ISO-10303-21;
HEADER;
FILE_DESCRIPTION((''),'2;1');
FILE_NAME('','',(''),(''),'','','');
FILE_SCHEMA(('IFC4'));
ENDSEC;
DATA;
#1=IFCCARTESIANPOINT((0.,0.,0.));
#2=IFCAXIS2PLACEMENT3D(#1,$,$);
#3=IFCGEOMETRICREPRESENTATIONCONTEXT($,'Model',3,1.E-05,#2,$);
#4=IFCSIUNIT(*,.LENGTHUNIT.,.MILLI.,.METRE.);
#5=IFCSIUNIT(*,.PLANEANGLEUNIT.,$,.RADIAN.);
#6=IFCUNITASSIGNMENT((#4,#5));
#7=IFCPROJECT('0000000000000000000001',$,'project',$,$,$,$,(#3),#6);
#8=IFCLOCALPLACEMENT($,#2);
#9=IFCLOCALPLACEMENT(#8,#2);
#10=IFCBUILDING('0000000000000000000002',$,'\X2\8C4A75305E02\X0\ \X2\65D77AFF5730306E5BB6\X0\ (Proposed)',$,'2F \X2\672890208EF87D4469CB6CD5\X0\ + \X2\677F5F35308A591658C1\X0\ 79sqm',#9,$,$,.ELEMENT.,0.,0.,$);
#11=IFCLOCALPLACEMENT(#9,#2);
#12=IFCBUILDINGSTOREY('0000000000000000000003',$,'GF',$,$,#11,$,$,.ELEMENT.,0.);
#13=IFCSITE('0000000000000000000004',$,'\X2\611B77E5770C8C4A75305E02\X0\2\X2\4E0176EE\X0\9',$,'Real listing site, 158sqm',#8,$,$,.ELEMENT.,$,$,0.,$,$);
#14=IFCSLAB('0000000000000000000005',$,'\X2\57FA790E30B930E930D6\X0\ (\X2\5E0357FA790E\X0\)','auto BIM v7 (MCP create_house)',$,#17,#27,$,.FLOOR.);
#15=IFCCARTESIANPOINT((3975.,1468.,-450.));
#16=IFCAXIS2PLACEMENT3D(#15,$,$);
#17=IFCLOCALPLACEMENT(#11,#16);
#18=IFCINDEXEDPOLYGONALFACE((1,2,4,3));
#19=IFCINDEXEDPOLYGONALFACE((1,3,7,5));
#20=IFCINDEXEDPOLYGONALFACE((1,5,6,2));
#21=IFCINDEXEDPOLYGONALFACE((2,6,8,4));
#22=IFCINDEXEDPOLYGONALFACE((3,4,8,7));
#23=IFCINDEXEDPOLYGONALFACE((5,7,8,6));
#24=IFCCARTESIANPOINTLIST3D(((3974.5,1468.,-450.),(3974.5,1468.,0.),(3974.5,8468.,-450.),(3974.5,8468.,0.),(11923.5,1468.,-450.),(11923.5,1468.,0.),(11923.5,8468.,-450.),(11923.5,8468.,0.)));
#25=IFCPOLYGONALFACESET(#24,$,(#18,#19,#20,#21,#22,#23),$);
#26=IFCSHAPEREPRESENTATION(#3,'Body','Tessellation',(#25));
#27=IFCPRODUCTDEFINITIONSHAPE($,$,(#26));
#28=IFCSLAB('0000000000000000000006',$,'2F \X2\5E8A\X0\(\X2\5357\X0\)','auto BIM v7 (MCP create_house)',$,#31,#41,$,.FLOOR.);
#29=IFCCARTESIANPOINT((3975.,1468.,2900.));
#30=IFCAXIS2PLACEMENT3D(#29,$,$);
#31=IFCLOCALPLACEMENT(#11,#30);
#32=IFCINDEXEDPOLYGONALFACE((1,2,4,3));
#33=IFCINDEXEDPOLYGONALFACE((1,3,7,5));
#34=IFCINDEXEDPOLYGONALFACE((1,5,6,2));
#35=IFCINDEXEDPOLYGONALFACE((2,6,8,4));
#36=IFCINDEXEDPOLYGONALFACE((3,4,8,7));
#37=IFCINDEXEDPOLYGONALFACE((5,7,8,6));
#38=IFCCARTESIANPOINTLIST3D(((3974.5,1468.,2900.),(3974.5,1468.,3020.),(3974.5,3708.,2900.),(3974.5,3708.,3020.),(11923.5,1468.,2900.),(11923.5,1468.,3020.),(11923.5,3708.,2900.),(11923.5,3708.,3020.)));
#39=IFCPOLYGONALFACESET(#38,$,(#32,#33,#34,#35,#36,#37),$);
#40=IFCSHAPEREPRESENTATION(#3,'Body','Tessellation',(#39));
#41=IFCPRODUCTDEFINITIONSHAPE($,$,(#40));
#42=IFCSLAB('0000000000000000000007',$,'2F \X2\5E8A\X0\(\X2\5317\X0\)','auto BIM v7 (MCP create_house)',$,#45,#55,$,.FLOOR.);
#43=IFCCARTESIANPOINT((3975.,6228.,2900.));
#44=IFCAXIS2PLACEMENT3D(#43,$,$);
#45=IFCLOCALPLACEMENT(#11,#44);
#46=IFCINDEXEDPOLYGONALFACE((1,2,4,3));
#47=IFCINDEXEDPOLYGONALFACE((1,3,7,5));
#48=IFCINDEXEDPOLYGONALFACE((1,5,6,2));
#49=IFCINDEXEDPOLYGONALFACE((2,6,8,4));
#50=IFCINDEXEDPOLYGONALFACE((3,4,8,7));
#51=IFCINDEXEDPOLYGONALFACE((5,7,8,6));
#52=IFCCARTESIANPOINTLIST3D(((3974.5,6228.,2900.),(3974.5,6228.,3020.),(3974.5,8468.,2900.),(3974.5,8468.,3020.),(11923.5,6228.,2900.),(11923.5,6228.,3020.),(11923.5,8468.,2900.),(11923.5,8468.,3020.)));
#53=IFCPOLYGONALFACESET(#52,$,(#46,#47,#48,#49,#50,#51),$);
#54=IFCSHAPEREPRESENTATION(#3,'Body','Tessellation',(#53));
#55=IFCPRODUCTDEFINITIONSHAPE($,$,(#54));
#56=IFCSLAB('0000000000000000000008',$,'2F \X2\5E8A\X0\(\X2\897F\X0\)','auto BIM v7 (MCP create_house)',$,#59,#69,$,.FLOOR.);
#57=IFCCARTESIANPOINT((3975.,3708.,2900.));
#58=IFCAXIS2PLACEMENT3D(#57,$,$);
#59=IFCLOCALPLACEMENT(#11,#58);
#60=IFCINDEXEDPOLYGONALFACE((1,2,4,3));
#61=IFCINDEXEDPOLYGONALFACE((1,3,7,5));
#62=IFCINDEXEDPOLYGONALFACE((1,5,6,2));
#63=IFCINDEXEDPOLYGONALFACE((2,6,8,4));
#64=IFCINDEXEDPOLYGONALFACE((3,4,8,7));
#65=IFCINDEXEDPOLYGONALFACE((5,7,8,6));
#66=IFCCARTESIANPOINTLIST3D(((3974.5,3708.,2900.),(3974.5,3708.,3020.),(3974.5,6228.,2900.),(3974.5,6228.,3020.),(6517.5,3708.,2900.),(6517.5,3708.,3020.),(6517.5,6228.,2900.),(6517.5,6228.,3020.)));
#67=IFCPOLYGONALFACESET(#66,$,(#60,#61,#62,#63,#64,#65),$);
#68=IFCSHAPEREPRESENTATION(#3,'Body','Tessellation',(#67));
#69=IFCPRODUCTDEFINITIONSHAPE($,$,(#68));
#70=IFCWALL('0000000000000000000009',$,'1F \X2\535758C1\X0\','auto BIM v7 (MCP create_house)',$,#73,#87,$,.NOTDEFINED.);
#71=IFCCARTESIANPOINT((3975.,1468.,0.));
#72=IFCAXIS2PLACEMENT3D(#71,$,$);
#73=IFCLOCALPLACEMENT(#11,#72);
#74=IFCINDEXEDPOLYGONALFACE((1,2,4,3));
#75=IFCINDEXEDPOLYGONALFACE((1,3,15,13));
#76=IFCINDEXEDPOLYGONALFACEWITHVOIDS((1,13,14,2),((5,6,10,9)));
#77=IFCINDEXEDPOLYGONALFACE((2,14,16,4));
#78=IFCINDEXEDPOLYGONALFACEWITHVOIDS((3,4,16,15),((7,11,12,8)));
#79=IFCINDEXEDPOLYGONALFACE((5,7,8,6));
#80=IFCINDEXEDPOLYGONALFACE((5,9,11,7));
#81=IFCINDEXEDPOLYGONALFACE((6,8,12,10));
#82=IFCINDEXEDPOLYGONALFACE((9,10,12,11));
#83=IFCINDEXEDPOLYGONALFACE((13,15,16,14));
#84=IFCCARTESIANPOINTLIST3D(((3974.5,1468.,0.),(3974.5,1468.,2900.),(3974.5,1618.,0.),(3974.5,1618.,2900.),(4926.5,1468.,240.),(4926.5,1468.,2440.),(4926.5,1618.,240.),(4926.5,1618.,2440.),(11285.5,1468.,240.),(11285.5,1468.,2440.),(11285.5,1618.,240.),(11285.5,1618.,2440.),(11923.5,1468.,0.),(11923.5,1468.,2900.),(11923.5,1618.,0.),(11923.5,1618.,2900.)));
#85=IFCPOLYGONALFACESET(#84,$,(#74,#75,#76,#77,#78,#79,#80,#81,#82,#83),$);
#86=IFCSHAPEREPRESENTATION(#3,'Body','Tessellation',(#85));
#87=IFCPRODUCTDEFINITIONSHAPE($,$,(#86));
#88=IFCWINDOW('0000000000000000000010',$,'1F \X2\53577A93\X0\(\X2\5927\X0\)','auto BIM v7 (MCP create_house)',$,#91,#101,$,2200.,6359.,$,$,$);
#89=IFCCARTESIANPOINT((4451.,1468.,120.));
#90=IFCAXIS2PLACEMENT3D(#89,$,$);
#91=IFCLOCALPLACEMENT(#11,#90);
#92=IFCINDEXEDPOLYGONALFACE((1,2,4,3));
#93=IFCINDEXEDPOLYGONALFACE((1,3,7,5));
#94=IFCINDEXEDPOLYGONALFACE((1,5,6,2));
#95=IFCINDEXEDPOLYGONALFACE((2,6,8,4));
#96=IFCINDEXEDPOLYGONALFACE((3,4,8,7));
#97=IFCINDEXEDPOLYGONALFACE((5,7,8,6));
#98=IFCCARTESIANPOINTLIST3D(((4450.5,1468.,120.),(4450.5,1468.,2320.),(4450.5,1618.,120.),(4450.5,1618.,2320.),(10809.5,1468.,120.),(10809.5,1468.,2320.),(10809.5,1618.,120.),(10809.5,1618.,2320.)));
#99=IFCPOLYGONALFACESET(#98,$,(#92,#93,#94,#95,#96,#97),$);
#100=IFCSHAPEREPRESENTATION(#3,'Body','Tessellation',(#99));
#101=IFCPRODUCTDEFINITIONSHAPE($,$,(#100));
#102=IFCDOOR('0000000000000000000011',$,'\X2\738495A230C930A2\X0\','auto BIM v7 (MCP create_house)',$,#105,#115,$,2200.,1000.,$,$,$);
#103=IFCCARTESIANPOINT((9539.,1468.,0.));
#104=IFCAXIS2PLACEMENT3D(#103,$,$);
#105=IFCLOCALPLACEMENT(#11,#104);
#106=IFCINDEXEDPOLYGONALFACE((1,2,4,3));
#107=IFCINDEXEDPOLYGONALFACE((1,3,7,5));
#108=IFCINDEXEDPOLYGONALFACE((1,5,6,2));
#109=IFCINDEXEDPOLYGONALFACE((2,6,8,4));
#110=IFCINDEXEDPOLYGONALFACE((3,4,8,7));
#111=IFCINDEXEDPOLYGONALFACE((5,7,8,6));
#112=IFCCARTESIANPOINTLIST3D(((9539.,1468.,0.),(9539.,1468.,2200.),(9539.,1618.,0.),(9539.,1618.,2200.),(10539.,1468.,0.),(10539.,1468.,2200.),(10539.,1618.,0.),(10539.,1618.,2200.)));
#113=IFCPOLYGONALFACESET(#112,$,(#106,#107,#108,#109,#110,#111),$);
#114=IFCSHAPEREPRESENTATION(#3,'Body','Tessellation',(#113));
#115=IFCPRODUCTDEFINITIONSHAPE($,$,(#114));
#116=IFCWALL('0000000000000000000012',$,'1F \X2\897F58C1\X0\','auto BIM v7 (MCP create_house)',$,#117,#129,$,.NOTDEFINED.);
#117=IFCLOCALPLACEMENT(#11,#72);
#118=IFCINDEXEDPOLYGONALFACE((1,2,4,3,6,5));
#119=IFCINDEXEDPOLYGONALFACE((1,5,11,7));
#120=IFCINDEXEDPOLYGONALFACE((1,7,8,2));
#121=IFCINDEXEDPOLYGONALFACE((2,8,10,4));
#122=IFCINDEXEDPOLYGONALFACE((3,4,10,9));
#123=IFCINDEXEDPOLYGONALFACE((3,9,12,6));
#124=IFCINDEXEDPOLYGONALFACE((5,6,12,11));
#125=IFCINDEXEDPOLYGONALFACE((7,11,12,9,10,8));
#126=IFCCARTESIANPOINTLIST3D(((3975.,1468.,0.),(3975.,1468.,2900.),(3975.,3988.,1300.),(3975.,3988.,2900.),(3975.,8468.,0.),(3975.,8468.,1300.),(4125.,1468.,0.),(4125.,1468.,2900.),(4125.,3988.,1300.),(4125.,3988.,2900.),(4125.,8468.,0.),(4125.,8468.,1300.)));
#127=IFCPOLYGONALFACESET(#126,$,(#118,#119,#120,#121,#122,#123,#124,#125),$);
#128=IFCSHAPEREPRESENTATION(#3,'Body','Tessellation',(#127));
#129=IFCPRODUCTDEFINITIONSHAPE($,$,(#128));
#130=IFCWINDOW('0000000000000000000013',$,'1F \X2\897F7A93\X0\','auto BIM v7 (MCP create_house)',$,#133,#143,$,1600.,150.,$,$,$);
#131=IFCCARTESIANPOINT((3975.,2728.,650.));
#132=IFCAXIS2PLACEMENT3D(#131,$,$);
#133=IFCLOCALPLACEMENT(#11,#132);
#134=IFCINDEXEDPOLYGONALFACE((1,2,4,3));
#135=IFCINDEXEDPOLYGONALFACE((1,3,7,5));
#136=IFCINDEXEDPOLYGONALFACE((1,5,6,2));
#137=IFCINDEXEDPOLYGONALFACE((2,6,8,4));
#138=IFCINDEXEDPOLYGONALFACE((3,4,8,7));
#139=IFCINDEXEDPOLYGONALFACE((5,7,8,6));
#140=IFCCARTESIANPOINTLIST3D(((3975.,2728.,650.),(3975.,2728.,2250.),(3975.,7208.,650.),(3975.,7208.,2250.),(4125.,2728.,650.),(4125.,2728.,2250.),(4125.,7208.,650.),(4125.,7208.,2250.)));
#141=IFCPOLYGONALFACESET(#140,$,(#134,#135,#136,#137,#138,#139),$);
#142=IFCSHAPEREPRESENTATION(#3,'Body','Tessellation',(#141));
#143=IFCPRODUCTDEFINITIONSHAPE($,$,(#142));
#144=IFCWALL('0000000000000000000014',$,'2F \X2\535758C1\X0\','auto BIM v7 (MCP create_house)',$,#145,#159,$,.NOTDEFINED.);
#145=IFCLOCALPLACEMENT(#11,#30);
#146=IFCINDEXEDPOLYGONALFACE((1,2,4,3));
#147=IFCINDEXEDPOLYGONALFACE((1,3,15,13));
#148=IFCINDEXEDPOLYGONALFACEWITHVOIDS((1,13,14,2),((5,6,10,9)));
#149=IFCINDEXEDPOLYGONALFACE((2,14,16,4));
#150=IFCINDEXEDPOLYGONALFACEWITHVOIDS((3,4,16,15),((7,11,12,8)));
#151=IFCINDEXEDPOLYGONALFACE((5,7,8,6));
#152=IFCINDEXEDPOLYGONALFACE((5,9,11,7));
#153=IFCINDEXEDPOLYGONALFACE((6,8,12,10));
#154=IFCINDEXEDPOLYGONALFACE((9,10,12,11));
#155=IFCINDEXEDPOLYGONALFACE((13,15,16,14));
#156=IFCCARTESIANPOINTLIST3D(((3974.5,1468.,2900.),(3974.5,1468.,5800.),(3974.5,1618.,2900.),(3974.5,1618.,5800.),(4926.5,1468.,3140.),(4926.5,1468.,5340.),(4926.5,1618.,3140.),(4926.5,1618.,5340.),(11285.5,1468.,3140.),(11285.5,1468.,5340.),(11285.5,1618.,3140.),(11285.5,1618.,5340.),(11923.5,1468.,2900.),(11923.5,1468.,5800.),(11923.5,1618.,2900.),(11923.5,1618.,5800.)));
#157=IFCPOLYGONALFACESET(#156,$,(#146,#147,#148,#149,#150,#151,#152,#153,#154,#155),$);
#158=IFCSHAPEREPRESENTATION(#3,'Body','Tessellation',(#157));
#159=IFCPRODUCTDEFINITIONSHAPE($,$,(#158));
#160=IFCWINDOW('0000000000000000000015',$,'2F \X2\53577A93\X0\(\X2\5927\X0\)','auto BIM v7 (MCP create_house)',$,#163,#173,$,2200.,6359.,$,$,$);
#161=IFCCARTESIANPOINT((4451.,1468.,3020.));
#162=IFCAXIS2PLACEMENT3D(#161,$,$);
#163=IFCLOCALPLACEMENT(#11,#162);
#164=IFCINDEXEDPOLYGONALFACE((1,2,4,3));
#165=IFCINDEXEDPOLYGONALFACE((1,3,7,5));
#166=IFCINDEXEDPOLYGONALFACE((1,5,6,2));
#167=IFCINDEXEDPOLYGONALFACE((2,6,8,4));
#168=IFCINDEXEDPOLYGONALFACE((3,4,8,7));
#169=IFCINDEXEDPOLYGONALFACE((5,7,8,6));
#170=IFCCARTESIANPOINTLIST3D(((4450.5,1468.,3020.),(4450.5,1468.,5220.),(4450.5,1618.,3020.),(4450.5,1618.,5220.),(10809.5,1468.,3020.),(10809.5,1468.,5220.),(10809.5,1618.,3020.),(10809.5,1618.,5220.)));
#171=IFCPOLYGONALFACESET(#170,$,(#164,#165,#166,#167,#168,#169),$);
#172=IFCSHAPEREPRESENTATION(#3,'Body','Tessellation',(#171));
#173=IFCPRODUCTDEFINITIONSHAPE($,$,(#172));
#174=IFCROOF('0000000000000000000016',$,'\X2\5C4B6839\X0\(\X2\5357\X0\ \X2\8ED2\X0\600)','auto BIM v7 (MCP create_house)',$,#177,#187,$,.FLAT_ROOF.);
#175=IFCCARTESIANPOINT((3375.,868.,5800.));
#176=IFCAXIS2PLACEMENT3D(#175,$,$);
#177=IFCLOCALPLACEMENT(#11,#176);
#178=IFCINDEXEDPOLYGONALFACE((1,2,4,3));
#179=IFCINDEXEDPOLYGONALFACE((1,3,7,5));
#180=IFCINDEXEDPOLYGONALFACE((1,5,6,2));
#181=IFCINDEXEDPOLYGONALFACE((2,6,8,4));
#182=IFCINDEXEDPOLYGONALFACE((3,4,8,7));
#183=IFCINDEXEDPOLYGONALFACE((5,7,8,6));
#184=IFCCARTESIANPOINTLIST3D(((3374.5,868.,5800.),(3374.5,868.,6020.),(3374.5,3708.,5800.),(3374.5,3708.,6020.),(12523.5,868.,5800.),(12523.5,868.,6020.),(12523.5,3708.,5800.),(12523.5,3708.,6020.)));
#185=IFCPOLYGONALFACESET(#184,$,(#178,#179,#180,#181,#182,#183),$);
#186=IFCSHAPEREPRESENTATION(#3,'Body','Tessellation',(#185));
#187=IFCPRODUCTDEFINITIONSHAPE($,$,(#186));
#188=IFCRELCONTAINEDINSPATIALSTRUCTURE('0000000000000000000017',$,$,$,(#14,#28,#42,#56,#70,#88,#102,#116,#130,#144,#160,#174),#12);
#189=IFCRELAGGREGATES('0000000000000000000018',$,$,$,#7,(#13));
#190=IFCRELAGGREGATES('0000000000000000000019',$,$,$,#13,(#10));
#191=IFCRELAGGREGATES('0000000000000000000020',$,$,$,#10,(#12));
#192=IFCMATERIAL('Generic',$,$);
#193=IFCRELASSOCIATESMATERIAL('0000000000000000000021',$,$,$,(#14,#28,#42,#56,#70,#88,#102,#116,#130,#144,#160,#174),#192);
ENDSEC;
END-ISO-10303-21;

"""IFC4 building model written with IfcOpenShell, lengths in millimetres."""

from ifc_helpers import new_model, si_unit, frame, frame_2d, origin, place, context, project, spatial, rectangle, extrude, material, element, fill, save


model = new_model("IFC4")

# Units and contexts
model_context = context("Model", 3, precision=1e-05, world=origin())
ifc_project = project(units=[si_unit("LENGTHUNIT", "METRE", prefix="MILLI"), si_unit("PLANEANGLEUNIT", "RADIAN")], contexts=[model_context])

# Site, building, storey
site_placement = place(None, origin())
site = spatial("IfcSite", under=ifc_project, at=site_placement, Name="愛知県豊田市2丁目9", ObjectType="Real listing site, 158sqm", CompositionType="ELEMENT", RefElevation=0.0)
building_placement = place(site_placement, origin())
building = spatial("IfcBuilding", under=site, at=building_placement, Name="豊田市 旗竿地の家 (Proposed)", ObjectType="2F 木造軸組構法 + 板張り外壁 79sqm", CompositionType="ELEMENT", ElevationOfRefHeight=0.0, ElevationOfTerrain=0.0)
storey_placement = place(building_placement, origin())
storey = spatial("IfcBuildingStorey", under=building, at=storey_placement, Name="GF", CompositionType="ELEMENT", Elevation=0.0)

# Slabs
ifc_material = material(Name="Generic")
slab_1_placement = place(storey_placement, frame((3975.0, 1468.0, -450.0)))
element("IfcSlab", 1, at=slab_1_placement, inside=storey, material=ifc_material, Name="基礎スラブ (布基礎)", Description="auto BIM v7 (MCP create_house)", PredefinedType="FLOOR", context=model_context, shape_type="SweptSolid", body=[
    extrude(rectangle(XDim=7949.0, YDim=7000.0, at=frame_2d((3974.0, 3500.0))), frame((3975.0, 1468.0, -450.0)), (0.0, 0.0, 1.0), 450.0),
])
slab_2_placement = place(storey_placement, frame((3975.0, 1468.0, 2900.0)))
element("IfcSlab", 2, at=slab_2_placement, inside=storey, material=ifc_material, Name="2F 床(南)", Description="auto BIM v7 (MCP create_house)", PredefinedType="FLOOR", context=model_context, shape_type="SweptSolid", body=[
    extrude(rectangle(XDim=7949.0, YDim=2240.0, at=frame_2d((3974.0, 1120.0))), frame((3975.0, 1468.0, 2900.0)), (0.0, 0.0, 1.0), 120.0),
])
slab_3_placement = place(storey_placement, frame((3975.0, 6228.0, 2900.0)))
element("IfcSlab", 3, at=slab_3_placement, inside=storey, material=ifc_material, Name="2F 床(北)", Description="auto BIM v7 (MCP create_house)", PredefinedType="FLOOR", context=model_context, shape_type="SweptSolid", body=[
    extrude(rectangle(XDim=7949.0, YDim=2240.0, at=frame_2d((3974.0, 1120.0))), frame((3975.0, 6228.0, 2900.0)), (0.0, 0.0, 1.0), 120.0),
])
slab_4_placement = place(storey_placement, frame((3975.0, 3708.0, 2900.0)))
element("IfcSlab", 4, at=slab_4_placement, inside=storey, material=ifc_material, Name="2F 床(西)", Description="auto BIM v7 (MCP create_house)", PredefinedType="FLOOR", context=model_context, shape_type="SweptSolid", body=[
    extrude(rectangle(XDim=2543.0, YDim=2520.0, at=frame_2d((1271.0, 1260.0))), frame((3975.0, 3708.0, 2900.0)), (0.0, 0.0, 1.0), 120.0),
])

# Wall, openings, window, door
wall_1_placement = place(storey_placement, frame((3975.0, 1468.0, 0.0)))
wall_1 = element("IfcWall", 5, at=wall_1_placement, inside=storey, material=ifc_material, Name="1F 南壁", Description="auto BIM v7 (MCP create_house)", PredefinedType="NOTDEFINED", context=model_context, shape_type="SweptSolid", body=[
    extrude(rectangle(XDim=7949.0, YDim=150.0, at=frame_2d((3974.0, 75.0))), frame((3975.0, 1468.0, 0.0)), (0.0, 0.0, 1.0), 2900.0),
])
opening_1_placement = place(storey_placement, frame((4451.0, 1468.0, 120.0)))
opening_1 = element("IfcOpeningElement", 6, at=opening_1_placement, cuts=wall_1, PredefinedType="NOTDEFINED", context=model_context, shape_type="SweptSolid", body=[
    extrude(rectangle(XDim=6359.0, YDim=150.0, at=frame_2d((3179.0, 75.0))), frame((4451.0, 1468.0, 120.0)), (0.0, 0.0, 1.0), 2200.0),
])
opening_2_placement = place(storey_placement, frame((9539.0, 1468.0, 0.0)))
opening_2 = element("IfcOpeningElement", 7, at=opening_2_placement, cuts=wall_1, PredefinedType="NOTDEFINED", context=model_context, shape_type="SweptSolid", body=[
    extrude(rectangle(XDim=1000.0, YDim=150.0, at=frame_2d((500.0, 75.0))), frame((9539.0, 1468.0, 0.0)), (0.0, 0.0, 1.0), 2200.0),
])
window_1_placement = place(storey_placement, frame((4451.0, 1468.0, 120.0)))
window_1 = element("IfcWindow", 8, at=window_1_placement, inside=storey, material=ifc_material, Name="1F 南窓(大)", Description="auto BIM v7 (MCP create_house)", OverallHeight=2200.0, OverallWidth=6359.0, context=model_context, shape_type="SweptSolid", body=[
    extrude(rectangle(XDim=6359.0, YDim=150.0, at=frame_2d((3179.0, 75.0))), frame((4451.0, 1468.0, 120.0)), (0.0, 0.0, 1.0), 2200.0),
])
fill(opening_1, window_1)
door_placement = place(storey_placement, frame((9539.0, 1468.0, 0.0)))
door = element("IfcDoor", 9, at=door_placement, inside=storey, material=ifc_material, Name="玄関ドア", Description="auto BIM v7 (MCP create_house)", OverallHeight=2200.0, OverallWidth=1000.0, context=model_context, shape_type="SweptSolid", body=[
    extrude(rectangle(XDim=1000.0, YDim=150.0, at=frame_2d((500.0, 75.0))), frame((9539.0, 1468.0, 0.0)), (0.0, 0.0, 1.0), 2200.0),
])
fill(opening_2, door)

# Walls, openings, windows
wall_2_placement = place(storey_placement, frame((3975.0, 1468.0, 0.0)))
wall_2 = element("IfcWall", 10, at=wall_2_placement, inside=storey, material=ifc_material, Name="1F 西壁", Description="auto BIM v7 (MCP create_house)", PredefinedType="NOTDEFINED", context=model_context, shape_type="SweptSolid", body=[
    extrude(rectangle(XDim=150.0, YDim=7000.0, at=frame_2d((75.0, 3500.0))), frame((3975.0, 1468.0, 0.0)), (0.0, 0.0, 1.0), 2900.0),
])
opening_3_placement = place(storey_placement, frame((3975.0, 2728.0, 650.0)))
opening_3 = element("IfcOpeningElement", 11, at=opening_3_placement, cuts=wall_2, PredefinedType="NOTDEFINED", context=model_context, shape_type="SweptSolid", body=[
    extrude(rectangle(XDim=150.0, YDim=4480.0, at=frame_2d((75.0, 2240.0))), frame((3975.0, 2728.0, 650.0)), (0.0, 0.0, 1.0), 1600.0),
])
window_2_placement = place(storey_placement, frame((3975.0, 2728.0, 650.0)))
window_2 = element("IfcWindow", 12, at=window_2_placement, inside=storey, material=ifc_material, Name="1F 西窓", Description="auto BIM v7 (MCP create_house)", OverallHeight=1600.0, OverallWidth=150.0, context=model_context, shape_type="SweptSolid", body=[
    extrude(rectangle(XDim=150.0, YDim=4480.0, at=frame_2d((75.0, 2240.0))), frame((3975.0, 2728.0, 650.0)), (0.0, 0.0, 1.0), 1600.0),
])
fill(opening_3, window_2)
wall_3_placement = place(storey_placement, frame((3975.0, 1468.0, 2900.0)))
wall_3 = element("IfcWall", 13, at=wall_3_placement, inside=storey, material=ifc_material, Name="2F 南壁", Description="auto BIM v7 (MCP create_house)", PredefinedType="NOTDEFINED", context=model_context, shape_type="SweptSolid", body=[
    extrude(rectangle(XDim=7949.0, YDim=150.0, at=frame_2d((3974.0, 75.0))), frame((3975.0, 1468.0, 2900.0)), (0.0, 0.0, 1.0), 2900.0),
])
opening_4_placement = place(storey_placement, frame((4451.0, 1468.0, 3020.0)))
opening_4 = element("IfcOpeningElement", 14, at=opening_4_placement, cuts=wall_3, PredefinedType="NOTDEFINED", context=model_context, shape_type="SweptSolid", body=[
    extrude(rectangle(XDim=6359.0, YDim=150.0, at=frame_2d((3179.0, 75.0))), frame((4451.0, 1468.0, 3020.0)), (0.0, 0.0, 1.0), 2200.0),
])
window_3_placement = place(storey_placement, frame((4451.0, 1468.0, 3020.0)))
window_3 = element("IfcWindow", 15, at=window_3_placement, inside=storey, material=ifc_material, Name="2F 南窓(大)", Description="auto BIM v7 (MCP create_house)", OverallHeight=2200.0, OverallWidth=6359.0, context=model_context, shape_type="SweptSolid", body=[
    extrude(rectangle(XDim=6359.0, YDim=150.0, at=frame_2d((3179.0, 75.0))), frame((4451.0, 1468.0, 3020.0)), (0.0, 0.0, 1.0), 2200.0),
])
fill(opening_4, window_3)

# Roof
roof_1_placement = place(storey_placement, frame((3375.0, 868.0, 5800.0)))
element("IfcRoof", 16, at=roof_1_placement, inside=storey, material=ifc_material, Name="屋根(南 軒600)", Description="auto BIM v7 (MCP create_house)", PredefinedType="FLAT_ROOF", context=model_context, shape_type="SweptSolid", body=[
    extrude(rectangle(XDim=9149.0, YDim=2840.0, at=frame_2d((4574.0, 1420.0))), frame((3375.0, 868.0, 5800.0)), (0.0, 0.0, 1.0), 220.0),
])

save(model, "model.ifc")
